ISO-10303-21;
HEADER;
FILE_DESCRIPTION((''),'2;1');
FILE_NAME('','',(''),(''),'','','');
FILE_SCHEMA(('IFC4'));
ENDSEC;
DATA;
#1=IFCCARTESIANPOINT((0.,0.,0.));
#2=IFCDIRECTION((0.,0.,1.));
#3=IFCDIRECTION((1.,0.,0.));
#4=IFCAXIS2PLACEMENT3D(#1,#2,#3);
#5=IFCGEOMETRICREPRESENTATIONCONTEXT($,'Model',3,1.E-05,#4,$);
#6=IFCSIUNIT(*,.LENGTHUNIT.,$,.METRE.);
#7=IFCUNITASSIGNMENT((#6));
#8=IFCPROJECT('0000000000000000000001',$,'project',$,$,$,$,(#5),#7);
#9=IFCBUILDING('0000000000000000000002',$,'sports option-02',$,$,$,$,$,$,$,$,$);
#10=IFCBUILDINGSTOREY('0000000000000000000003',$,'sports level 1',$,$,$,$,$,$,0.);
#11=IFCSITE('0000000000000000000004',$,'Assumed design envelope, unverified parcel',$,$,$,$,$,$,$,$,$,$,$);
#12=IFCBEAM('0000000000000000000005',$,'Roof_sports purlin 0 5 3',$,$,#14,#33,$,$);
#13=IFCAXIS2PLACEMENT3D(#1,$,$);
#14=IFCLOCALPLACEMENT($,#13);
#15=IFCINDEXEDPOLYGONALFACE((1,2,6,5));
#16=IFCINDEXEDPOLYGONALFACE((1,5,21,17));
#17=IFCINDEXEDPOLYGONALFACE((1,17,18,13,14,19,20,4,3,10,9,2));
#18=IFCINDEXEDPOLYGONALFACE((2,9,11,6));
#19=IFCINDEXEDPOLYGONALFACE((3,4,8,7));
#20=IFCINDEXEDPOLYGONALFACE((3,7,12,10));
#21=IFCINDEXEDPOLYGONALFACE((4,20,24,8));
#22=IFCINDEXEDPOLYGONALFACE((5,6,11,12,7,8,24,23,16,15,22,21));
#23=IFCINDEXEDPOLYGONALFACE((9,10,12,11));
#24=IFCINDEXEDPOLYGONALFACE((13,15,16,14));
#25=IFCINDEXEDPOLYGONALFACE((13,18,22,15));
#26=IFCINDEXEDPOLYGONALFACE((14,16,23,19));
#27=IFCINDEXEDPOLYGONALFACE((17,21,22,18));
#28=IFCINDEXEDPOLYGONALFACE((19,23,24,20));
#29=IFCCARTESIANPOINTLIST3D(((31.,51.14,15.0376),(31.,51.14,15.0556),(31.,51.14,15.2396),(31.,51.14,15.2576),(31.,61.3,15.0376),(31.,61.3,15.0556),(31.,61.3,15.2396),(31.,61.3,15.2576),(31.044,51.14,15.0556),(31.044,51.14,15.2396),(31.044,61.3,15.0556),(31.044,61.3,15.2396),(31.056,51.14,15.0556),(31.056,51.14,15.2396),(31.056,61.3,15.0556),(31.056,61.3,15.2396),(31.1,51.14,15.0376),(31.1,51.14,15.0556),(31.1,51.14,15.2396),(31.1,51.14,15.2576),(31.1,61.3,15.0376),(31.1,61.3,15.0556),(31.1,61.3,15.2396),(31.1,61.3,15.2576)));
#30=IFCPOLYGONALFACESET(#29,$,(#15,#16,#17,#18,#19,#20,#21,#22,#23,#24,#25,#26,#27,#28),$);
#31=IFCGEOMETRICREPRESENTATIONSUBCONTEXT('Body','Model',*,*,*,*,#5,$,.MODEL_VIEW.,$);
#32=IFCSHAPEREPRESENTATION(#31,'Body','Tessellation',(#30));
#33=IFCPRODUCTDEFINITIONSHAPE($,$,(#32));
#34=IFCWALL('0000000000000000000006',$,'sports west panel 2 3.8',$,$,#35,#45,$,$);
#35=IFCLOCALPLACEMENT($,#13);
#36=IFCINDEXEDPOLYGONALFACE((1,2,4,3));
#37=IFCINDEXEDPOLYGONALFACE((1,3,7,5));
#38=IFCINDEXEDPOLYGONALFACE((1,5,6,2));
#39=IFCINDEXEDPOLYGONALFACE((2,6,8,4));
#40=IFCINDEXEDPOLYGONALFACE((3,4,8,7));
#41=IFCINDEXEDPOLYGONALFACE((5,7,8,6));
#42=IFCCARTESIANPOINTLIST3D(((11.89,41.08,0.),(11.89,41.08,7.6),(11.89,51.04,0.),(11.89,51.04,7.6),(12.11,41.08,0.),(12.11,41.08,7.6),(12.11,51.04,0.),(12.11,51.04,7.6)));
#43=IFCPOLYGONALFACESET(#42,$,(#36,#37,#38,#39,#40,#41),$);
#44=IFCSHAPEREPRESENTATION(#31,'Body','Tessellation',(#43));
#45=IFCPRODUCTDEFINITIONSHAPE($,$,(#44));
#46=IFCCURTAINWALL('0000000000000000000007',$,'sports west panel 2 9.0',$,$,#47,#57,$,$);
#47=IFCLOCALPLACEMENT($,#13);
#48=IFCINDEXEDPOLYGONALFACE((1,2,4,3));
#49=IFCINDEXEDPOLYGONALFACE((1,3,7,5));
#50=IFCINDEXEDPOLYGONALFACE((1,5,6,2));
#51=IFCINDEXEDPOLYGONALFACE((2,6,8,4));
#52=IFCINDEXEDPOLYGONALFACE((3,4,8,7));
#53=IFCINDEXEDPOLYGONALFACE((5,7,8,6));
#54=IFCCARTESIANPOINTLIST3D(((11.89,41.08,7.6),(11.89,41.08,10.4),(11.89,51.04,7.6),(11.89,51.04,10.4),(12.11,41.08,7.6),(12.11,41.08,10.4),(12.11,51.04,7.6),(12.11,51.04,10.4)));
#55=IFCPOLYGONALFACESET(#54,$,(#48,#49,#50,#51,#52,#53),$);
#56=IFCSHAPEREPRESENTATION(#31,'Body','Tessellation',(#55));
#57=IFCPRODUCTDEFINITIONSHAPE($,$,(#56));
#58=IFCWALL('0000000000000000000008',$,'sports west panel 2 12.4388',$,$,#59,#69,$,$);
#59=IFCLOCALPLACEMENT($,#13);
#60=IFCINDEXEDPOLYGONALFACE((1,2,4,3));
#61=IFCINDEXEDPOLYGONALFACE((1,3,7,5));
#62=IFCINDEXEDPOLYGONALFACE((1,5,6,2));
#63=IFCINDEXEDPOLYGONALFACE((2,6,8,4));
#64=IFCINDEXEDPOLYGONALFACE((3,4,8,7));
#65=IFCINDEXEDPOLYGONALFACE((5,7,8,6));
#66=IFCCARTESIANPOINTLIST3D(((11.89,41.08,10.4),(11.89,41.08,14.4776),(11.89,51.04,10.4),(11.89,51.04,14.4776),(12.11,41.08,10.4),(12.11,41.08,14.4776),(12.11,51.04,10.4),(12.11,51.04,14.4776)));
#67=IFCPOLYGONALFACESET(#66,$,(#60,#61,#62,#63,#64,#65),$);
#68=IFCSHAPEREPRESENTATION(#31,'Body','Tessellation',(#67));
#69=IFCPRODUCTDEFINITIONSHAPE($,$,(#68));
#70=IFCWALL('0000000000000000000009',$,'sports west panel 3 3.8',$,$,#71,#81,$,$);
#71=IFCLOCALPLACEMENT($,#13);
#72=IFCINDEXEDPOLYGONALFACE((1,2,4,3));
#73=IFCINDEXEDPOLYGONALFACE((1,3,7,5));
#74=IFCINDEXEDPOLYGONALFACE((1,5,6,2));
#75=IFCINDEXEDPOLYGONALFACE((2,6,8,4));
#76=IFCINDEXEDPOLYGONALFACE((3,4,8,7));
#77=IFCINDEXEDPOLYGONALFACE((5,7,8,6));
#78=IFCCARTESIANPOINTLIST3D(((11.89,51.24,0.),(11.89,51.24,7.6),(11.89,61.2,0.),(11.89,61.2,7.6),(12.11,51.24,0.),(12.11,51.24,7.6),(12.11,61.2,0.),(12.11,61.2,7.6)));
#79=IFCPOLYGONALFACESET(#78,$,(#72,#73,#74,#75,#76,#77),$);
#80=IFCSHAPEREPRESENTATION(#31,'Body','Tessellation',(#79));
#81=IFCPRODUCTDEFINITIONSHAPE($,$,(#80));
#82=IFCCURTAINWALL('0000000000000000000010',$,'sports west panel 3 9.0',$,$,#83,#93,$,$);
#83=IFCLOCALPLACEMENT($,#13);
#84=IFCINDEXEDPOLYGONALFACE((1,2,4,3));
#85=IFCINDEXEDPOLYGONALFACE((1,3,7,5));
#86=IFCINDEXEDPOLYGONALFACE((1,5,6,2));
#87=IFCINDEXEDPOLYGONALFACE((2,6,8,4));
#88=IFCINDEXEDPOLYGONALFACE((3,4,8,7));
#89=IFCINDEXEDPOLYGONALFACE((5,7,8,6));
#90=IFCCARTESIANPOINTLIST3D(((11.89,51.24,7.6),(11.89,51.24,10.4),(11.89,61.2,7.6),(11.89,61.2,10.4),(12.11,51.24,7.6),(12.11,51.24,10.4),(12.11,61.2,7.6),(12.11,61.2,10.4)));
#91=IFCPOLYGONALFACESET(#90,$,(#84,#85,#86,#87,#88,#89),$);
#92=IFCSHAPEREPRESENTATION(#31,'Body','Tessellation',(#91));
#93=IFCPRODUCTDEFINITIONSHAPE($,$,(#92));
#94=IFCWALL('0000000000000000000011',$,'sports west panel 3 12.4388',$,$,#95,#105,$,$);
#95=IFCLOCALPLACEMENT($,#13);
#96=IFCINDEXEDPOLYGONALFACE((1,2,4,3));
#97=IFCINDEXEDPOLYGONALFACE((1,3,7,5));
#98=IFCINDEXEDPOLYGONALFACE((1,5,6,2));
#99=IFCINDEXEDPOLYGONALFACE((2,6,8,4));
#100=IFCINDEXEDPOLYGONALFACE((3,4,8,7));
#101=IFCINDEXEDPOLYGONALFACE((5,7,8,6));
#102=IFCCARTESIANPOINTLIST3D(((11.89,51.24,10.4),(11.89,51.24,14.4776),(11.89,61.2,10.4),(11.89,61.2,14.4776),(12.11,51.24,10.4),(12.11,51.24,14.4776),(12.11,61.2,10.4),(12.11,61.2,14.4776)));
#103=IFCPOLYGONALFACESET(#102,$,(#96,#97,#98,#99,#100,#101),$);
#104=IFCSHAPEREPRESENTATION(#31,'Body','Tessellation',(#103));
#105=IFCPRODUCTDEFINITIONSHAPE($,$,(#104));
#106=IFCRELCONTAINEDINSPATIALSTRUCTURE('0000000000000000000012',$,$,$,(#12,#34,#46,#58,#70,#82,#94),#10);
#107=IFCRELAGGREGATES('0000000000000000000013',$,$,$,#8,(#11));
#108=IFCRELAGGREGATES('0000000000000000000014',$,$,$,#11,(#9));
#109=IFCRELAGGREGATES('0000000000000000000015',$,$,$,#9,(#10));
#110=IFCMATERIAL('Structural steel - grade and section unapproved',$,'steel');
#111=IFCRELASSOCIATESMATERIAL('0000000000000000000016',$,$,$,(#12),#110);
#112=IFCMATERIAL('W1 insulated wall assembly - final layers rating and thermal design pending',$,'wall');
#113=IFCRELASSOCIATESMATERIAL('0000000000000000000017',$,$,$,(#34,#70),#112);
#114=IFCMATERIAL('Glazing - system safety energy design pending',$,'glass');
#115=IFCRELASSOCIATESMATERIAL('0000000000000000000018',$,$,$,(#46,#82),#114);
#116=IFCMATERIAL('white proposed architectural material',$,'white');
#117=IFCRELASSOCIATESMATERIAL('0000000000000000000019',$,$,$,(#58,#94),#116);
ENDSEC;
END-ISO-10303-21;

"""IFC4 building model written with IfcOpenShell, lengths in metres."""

from ifc_helpers import new_model, si_unit, frame, origin_with_axes, place, context, subcontext, project, spatial, rectangle, i_section, extrude, material, element, save


model = new_model("IFC4")

# Units and contexts
model_context = context("Model", 3, precision=1e-05, world=origin_with_axes())
body_context = subcontext(model_context, "Body", "Model", "MODEL_VIEW")
ifc_project = project(units=[si_unit("LENGTHUNIT", "METRE")], contexts=[model_context])

# Site, building, storey
site = spatial("IfcSite", under=ifc_project, Name="Assumed design envelope, unverified parcel")
building = spatial("IfcBuilding", under=site, Name="sports option-02")
storey = spatial("IfcBuildingStorey", under=building, Name="sports level 1", Elevation=0.0)

# Shared definitions
ifc_material_1 = material(Name="Structural steel - grade and section unapproved", Category="steel")

# Beam
for number, where, z_axis, x_axis, name in (
    (1, (31.05, 51.14, 15.1476), (0.0, 1.0, 0.0), (-1.0, 0.0, 0.0), "Roof_sports purlin 0 5 3"),
):
    element("IfcBeam", number, at=place(None, frame(where, z_axis=z_axis, x_axis=x_axis)), inside=storey, material=ifc_material_1, Name=name, context=body_context, shape_type="SweptSolid", body=[
        extrude(i_section(OverallWidth=0.1, OverallDepth=0.22, WebThickness=0.012, FlangeThickness=0.018, FilletRadius=0.0), origin_with_axes(), (0.0, 0.0, 1.0), 10.16),
    ])

# Wall
ifc_material_2 = material(Name="W1 insulated wall assembly - final layers rating and thermal design pending", Category="wall")
wall_1_placement = place(None, frame((12.0, 46.06, 0.0), z_axis=(0.0, 0.0, 1.0), x_axis=(1.0, 0.0, 0.0)))
element("IfcWall", 2, at=wall_1_placement, inside=storey, material=ifc_material_2, Name="sports west panel 2 3.8", context=body_context, shape_type="SweptSolid", body=[
    extrude(rectangle(XDim=0.22, YDim=9.96), origin_with_axes(), (0.0, 0.0, 1.0), 7.6),
])

# Curtain wall
ifc_material_3 = material(Name="Glazing - system safety energy design pending", Category="glass")
curtain_wall_1_placement = place(None, frame((12.0, 46.06, 7.6), z_axis=(0.0, 0.0, 1.0), x_axis=(1.0, 0.0, 0.0)))
element("IfcCurtainWall", 3, at=curtain_wall_1_placement, inside=storey, material=ifc_material_3, Name="sports west panel 2 9.0", context=body_context, shape_type="SweptSolid", body=[
    extrude(rectangle(XDim=0.22, YDim=9.96), origin_with_axes(), (0.0, 0.0, 1.0), 2.8),
])

# Walls
ifc_material_4 = material(Name="white proposed architectural material", Category="white")
wall_2_placement = place(None, frame((12.0, 46.06, 10.4), z_axis=(0.0, 0.0, 1.0), x_axis=(1.0, 0.0, 0.0)))
element("IfcWall", 4, at=wall_2_placement, inside=storey, material=ifc_material_4, Name="sports west panel 2 12.4388", context=body_context, shape_type="SweptSolid", body=[
    extrude(rectangle(XDim=0.22, YDim=9.96), origin_with_axes(), (0.0, 0.0, 1.0), 4.0776),
])
wall_3_placement = place(None, frame((12.0, 56.22, 0.0), z_axis=(0.0, 0.0, 1.0), x_axis=(1.0, 0.0, 0.0)))
element("IfcWall", 5, at=wall_3_placement, inside=storey, material=ifc_material_2, Name="sports west panel 3 3.8", context=body_context, shape_type="SweptSolid", body=[
    extrude(rectangle(XDim=0.22, YDim=9.96), origin_with_axes(), (0.0, 0.0, 1.0), 7.6),
])

# Curtain wall
curtain_wall_2_placement = place(None, frame((12.0, 56.22, 7.6), z_axis=(0.0, 0.0, 1.0), x_axis=(1.0, 0.0, 0.0)))
element("IfcCurtainWall", 6, at=curtain_wall_2_placement, inside=storey, material=ifc_material_3, Name="sports west panel 3 9.0", context=body_context, shape_type="SweptSolid", body=[
    extrude(rectangle(XDim=0.22, YDim=9.96), origin_with_axes(), (0.0, 0.0, 1.0), 2.8),
])

# Wall
wall_4_placement = place(None, frame((12.0, 56.22, 10.4), z_axis=(0.0, 0.0, 1.0), x_axis=(1.0, 0.0, 0.0)))
element("IfcWall", 7, at=wall_4_placement, inside=storey, material=ifc_material_4, Name="sports west panel 3 12.4388", context=body_context, shape_type="SweptSolid", body=[
    extrude(rectangle(XDim=0.22, YDim=9.96), origin_with_axes(), (0.0, 0.0, 1.0), 4.0776),
])

save(model, "model.ifc")
